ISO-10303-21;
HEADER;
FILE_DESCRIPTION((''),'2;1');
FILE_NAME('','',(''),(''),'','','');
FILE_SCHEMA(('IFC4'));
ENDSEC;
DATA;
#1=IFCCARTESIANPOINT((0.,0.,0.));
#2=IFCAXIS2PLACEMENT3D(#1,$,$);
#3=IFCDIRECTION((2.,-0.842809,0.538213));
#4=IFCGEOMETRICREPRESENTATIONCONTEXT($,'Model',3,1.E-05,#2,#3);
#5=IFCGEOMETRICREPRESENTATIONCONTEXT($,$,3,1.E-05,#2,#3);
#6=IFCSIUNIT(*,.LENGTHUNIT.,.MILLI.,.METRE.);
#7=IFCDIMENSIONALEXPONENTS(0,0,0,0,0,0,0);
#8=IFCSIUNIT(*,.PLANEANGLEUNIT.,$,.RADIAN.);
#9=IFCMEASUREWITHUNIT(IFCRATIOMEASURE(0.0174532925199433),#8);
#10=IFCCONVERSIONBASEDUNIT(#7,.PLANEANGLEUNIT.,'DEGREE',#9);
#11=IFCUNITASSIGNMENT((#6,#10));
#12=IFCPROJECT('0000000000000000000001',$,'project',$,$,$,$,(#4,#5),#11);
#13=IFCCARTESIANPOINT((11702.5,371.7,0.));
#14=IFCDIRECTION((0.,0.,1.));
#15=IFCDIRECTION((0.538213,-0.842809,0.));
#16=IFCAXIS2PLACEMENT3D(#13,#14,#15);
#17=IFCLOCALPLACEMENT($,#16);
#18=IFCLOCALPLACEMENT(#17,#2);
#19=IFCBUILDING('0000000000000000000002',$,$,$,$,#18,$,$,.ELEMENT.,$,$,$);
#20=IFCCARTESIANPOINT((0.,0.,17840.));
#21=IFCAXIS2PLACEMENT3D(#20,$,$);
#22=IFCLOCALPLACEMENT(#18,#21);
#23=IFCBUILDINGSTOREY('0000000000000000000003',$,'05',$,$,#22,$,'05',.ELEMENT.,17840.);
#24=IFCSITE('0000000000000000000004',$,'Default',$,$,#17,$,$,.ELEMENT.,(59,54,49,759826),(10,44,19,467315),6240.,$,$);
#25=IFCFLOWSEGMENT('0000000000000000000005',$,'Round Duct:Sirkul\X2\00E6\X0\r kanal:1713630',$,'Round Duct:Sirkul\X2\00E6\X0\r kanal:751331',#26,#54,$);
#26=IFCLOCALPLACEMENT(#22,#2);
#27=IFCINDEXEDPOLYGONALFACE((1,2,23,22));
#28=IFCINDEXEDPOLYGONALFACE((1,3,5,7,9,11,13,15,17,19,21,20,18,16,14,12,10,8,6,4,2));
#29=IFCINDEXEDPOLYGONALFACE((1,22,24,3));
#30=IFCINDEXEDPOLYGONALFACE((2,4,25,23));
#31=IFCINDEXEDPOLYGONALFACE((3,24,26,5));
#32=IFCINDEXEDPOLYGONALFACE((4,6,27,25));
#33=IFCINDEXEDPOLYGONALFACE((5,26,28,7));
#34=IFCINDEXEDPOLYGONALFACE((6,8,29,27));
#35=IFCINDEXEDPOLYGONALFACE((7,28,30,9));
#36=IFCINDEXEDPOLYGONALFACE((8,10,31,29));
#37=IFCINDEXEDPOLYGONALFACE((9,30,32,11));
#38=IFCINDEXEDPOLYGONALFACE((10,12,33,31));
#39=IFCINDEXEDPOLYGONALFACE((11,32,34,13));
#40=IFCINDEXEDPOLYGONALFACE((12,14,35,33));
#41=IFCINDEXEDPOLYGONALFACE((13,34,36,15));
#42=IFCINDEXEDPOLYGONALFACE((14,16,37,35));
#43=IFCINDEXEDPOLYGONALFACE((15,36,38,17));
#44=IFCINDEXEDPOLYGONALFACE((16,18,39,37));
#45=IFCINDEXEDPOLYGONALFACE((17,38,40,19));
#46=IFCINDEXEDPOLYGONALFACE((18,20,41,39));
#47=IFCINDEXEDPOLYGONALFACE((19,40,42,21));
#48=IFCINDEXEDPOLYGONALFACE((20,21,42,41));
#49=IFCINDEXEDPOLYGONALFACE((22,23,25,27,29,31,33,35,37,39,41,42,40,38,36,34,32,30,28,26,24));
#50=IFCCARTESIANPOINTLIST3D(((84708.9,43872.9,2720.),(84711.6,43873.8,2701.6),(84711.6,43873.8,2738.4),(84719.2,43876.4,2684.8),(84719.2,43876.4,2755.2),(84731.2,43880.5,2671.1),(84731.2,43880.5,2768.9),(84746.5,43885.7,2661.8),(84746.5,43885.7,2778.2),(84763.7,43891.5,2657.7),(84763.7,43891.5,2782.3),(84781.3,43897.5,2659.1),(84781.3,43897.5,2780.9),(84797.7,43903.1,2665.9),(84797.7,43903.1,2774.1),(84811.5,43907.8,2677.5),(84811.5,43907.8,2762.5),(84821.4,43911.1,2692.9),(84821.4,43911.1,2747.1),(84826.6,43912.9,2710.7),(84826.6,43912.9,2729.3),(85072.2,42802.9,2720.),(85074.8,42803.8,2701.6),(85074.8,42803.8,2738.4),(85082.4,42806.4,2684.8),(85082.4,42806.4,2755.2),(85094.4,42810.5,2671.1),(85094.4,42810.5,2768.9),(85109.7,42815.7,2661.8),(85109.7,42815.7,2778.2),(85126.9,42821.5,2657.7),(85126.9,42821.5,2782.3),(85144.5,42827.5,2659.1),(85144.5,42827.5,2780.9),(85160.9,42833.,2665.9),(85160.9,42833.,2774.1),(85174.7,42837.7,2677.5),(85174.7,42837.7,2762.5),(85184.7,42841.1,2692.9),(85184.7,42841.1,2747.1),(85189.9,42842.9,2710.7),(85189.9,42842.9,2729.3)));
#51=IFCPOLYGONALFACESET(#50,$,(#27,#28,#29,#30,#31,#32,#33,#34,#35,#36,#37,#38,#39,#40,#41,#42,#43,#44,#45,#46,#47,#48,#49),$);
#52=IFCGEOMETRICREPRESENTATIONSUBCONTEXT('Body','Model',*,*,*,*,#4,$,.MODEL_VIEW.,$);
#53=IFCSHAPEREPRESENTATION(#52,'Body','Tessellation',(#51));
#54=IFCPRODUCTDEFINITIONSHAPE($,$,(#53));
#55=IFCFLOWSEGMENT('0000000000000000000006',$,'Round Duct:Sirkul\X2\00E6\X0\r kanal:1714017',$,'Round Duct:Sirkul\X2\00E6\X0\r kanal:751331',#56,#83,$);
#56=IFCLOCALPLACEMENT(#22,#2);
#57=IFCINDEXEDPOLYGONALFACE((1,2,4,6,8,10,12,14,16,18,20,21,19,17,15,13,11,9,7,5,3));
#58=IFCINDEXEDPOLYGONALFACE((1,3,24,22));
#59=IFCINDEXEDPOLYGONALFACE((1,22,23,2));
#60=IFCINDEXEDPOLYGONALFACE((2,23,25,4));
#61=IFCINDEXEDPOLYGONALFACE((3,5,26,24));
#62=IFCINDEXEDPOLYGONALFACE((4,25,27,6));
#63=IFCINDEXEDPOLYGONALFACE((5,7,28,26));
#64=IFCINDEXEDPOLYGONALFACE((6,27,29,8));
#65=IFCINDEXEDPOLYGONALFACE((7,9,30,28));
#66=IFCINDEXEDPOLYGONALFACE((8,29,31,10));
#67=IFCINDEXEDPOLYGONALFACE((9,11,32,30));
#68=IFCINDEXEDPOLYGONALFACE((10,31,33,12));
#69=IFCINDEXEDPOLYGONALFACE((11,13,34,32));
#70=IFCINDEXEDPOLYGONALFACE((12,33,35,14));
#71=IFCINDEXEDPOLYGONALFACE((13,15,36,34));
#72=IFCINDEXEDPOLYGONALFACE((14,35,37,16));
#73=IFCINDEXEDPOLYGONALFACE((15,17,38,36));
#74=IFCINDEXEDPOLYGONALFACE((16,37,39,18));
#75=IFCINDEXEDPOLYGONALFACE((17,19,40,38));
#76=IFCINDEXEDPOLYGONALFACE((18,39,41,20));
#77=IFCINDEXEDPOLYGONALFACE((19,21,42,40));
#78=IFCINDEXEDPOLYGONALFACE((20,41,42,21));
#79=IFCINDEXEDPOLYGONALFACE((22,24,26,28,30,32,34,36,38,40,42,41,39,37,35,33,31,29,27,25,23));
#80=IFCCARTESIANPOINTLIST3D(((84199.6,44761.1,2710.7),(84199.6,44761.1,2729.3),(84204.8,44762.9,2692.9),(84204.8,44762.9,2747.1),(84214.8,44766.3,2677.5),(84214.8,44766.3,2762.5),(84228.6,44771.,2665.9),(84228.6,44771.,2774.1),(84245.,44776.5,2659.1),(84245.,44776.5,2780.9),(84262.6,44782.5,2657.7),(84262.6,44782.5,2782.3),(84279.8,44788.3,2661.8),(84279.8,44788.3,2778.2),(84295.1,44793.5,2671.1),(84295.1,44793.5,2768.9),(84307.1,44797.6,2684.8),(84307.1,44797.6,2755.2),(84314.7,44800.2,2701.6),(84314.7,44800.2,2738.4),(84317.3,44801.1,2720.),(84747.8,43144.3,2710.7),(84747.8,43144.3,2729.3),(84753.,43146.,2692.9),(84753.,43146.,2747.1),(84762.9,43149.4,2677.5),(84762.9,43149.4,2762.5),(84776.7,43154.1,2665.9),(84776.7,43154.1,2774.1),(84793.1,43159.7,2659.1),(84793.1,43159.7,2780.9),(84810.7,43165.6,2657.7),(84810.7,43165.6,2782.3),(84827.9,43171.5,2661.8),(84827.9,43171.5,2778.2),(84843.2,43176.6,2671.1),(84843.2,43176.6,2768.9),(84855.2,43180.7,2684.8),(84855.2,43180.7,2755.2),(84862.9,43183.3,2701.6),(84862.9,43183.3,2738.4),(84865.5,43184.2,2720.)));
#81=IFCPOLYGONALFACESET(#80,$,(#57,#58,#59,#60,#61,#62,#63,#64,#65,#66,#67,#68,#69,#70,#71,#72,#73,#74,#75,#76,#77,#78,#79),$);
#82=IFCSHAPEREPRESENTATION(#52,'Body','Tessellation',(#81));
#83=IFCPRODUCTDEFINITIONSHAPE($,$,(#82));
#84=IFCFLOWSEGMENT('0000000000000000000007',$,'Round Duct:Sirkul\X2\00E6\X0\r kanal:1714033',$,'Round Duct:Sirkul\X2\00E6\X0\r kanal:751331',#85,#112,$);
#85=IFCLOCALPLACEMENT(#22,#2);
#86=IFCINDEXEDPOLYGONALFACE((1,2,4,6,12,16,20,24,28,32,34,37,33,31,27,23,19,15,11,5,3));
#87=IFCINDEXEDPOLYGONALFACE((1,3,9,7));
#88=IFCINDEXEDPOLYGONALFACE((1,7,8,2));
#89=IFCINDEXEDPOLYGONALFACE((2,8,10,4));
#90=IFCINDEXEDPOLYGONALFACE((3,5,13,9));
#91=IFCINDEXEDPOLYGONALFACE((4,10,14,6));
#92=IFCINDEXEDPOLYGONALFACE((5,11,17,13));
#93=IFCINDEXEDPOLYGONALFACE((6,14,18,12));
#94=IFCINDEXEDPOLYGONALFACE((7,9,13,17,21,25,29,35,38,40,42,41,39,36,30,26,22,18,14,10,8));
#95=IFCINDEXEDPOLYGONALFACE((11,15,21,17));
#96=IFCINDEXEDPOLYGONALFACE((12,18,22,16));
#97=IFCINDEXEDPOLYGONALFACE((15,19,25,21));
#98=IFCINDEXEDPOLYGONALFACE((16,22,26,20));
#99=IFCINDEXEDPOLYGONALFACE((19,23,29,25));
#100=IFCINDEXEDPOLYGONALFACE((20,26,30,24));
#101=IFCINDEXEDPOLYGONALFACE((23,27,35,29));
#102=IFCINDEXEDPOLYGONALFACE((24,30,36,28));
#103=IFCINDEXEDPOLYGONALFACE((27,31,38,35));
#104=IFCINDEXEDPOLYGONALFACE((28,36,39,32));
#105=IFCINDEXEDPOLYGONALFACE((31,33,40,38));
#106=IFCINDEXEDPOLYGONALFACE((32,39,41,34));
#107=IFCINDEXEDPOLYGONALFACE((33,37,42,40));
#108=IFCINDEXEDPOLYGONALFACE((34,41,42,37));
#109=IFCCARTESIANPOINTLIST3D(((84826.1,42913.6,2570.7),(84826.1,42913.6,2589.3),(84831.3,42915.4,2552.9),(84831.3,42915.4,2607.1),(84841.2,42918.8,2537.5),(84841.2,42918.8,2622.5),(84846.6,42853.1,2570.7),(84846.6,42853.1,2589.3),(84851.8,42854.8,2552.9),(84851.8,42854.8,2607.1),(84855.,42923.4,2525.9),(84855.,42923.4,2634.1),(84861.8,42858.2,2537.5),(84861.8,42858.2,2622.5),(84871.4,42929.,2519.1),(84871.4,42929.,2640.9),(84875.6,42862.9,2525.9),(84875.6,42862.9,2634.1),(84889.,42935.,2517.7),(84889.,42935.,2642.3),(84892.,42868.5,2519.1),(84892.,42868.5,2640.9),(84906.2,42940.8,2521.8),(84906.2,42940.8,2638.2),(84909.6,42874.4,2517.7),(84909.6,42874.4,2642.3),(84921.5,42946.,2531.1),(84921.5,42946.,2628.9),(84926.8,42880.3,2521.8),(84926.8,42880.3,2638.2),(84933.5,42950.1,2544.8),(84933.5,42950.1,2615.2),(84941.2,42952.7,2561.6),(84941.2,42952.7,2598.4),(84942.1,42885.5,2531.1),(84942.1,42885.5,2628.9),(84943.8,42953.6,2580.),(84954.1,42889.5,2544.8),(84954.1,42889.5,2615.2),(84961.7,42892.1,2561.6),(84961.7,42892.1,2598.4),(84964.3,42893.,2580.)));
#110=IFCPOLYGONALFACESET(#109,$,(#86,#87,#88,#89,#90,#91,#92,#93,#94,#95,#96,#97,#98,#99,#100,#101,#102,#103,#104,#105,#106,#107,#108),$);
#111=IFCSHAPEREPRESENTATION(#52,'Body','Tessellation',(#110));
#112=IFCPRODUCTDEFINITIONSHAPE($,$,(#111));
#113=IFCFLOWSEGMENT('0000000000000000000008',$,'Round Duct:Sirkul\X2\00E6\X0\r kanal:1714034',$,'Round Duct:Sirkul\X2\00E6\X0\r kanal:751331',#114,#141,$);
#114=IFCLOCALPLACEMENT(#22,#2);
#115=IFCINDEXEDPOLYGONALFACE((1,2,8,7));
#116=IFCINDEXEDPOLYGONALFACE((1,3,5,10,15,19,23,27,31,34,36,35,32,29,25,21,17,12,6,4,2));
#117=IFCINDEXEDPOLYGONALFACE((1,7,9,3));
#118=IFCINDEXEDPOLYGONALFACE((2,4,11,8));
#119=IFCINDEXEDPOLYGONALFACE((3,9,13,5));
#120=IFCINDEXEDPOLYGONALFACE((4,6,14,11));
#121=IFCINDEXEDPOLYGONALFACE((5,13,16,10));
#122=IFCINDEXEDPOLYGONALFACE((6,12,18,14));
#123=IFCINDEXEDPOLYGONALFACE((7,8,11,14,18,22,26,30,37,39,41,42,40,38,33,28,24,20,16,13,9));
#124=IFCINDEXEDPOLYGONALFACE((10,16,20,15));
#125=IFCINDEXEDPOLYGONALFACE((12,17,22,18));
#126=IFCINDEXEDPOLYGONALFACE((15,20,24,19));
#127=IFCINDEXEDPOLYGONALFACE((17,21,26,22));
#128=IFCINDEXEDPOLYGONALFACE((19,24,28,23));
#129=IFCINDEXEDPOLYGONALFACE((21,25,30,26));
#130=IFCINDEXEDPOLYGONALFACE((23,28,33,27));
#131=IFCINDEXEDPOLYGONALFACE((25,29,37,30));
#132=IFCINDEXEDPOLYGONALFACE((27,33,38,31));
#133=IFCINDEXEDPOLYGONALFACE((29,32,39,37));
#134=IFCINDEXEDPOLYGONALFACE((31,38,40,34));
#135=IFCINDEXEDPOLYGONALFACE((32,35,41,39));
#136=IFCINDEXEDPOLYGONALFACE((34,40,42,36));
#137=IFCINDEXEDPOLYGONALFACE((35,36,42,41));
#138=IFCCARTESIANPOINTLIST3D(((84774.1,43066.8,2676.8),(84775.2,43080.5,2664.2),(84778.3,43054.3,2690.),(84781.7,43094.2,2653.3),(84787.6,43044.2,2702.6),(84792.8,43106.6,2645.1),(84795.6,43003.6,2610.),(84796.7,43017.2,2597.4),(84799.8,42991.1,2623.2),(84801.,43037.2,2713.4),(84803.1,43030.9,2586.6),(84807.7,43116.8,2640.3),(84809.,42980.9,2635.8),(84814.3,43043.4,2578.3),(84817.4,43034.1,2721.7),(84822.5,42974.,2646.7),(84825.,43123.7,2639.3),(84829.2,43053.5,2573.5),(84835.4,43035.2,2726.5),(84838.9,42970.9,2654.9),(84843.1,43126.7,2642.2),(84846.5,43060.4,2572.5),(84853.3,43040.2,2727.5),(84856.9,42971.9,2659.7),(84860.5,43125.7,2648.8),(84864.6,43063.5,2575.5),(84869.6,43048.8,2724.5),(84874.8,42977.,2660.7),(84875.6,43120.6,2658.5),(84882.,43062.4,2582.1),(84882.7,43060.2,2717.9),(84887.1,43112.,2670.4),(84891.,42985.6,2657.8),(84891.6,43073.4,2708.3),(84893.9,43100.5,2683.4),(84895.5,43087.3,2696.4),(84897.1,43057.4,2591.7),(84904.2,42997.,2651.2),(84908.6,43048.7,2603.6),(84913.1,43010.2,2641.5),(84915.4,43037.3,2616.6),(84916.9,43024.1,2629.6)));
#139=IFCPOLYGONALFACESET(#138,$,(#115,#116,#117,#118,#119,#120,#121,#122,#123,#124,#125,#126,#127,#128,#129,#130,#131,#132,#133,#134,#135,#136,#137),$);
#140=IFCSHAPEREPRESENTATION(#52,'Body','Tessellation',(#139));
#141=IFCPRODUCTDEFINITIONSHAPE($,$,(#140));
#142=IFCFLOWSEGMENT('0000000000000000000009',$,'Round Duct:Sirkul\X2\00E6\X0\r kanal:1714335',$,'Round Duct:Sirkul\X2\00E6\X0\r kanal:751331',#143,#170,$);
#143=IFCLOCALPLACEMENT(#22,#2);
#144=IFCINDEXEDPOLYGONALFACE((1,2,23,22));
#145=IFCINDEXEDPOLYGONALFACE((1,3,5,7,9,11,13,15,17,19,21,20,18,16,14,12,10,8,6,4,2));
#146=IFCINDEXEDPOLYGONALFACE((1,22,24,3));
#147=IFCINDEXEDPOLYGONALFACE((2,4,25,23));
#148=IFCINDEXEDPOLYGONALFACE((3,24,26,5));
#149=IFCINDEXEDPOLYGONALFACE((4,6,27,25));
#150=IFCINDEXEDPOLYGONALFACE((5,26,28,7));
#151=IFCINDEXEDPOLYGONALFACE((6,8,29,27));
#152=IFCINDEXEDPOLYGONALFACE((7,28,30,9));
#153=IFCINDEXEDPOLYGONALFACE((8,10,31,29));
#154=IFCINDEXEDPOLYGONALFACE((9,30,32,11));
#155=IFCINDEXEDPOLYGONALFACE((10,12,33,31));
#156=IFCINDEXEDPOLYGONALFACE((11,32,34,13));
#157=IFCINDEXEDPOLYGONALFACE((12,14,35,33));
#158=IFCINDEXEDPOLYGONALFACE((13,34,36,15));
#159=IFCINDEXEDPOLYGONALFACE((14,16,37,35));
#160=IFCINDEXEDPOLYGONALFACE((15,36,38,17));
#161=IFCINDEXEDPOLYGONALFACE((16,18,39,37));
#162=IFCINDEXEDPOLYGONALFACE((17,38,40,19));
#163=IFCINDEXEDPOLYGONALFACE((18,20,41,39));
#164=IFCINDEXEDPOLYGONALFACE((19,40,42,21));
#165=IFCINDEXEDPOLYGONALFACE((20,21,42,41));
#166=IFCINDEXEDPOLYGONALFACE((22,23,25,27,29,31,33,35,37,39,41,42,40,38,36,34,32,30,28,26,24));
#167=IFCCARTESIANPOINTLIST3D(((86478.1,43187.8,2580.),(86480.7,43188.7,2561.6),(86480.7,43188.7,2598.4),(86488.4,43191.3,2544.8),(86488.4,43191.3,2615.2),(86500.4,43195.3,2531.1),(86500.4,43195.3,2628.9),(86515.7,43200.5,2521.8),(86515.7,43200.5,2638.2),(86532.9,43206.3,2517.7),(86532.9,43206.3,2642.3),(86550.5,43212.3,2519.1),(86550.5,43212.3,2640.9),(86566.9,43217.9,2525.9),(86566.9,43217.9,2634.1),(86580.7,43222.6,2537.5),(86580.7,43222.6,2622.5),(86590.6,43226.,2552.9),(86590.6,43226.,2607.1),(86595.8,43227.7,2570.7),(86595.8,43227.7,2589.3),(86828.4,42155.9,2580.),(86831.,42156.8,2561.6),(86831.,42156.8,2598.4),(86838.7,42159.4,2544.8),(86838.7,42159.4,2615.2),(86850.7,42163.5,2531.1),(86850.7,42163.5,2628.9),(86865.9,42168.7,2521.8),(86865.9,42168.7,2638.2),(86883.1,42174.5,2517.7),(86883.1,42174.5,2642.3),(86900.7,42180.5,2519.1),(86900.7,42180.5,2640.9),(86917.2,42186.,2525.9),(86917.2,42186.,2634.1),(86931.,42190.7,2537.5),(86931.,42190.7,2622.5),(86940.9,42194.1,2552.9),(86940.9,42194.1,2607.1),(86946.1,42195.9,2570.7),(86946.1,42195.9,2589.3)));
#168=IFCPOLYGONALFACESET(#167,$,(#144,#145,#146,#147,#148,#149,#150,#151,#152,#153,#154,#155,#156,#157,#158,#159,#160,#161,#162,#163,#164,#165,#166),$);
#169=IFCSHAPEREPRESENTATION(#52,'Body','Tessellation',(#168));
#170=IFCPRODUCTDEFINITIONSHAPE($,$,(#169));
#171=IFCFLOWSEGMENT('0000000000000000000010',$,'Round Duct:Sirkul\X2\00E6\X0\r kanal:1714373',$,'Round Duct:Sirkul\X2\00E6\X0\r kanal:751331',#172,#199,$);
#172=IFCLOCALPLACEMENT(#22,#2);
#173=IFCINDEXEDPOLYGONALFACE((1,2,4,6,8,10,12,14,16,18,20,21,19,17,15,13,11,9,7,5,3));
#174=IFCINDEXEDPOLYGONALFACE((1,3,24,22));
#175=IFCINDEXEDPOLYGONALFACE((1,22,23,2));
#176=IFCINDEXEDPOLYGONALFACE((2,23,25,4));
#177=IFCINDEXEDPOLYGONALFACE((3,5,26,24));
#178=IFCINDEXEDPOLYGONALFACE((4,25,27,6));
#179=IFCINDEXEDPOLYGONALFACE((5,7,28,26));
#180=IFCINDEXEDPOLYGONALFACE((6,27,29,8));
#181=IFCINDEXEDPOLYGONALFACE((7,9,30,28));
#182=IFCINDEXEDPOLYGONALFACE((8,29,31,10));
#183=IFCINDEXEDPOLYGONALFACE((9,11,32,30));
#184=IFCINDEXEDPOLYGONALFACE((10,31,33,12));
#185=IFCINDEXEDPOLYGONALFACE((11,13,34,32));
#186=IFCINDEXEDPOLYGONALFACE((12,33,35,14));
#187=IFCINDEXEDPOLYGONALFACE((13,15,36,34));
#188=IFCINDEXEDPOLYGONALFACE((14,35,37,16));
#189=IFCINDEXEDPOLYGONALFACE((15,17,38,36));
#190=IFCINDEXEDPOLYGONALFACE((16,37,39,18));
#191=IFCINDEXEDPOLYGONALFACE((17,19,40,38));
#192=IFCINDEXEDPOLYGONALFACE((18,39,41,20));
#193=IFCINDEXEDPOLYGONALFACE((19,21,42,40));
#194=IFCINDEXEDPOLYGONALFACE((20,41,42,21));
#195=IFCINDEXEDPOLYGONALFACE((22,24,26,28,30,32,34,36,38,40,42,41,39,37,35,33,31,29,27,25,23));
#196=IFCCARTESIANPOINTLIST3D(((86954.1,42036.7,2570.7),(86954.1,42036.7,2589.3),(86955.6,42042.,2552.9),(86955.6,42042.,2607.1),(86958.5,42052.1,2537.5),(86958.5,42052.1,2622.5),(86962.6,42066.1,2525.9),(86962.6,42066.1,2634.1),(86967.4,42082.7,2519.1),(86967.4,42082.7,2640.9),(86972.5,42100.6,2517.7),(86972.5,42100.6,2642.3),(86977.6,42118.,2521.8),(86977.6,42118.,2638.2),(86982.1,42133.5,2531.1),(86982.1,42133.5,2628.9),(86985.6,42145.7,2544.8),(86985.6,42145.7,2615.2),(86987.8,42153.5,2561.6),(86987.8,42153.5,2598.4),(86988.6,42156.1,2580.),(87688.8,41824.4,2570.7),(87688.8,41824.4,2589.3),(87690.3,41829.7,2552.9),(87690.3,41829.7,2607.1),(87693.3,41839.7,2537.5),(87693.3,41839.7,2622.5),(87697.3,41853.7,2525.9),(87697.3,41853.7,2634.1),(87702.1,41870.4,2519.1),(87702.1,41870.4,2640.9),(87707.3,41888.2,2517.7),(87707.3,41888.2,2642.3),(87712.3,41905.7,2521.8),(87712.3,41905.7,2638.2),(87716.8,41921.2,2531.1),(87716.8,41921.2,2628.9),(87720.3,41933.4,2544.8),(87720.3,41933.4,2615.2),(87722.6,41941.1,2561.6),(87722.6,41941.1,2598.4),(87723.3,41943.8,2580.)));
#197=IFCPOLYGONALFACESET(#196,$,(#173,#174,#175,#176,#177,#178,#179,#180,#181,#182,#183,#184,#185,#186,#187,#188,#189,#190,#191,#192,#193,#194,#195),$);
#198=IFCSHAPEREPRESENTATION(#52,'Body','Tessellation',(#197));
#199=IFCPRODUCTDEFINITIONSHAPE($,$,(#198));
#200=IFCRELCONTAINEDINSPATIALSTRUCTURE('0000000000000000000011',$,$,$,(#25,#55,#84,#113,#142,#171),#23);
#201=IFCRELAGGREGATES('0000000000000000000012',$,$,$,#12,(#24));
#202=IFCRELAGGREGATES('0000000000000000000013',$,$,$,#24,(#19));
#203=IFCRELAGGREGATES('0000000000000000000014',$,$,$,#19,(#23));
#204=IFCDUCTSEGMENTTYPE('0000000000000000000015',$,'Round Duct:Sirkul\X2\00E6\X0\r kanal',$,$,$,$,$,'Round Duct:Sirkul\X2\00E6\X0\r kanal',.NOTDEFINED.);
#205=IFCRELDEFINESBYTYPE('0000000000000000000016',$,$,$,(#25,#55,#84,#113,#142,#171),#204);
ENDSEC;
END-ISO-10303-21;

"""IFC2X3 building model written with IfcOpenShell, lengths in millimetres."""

from ifc_helpers import new_model, entity, si_unit, converted_unit, direction, frame, origin, origin_2d_with_axis, place, context, subcontext, project, spatial, circle, extrude, type_object, element, save


model = new_model("IFC2X3")

# Units and contexts
model_context = context("Model", 3, precision=1e-05, world=origin(), true_north=direction((2.0, -0.842809, 0.538213)))
context_of_model = context(None, 3, precision=1e-05, world=origin(), true_north=direction((2.0, -0.842809, 0.538213)))
body_context = subcontext(model_context, "Body", "Model", "MODEL_VIEW")
ifc_project = project(units=[si_unit("LENGTHUNIT", "METRE", prefix="MILLI"), converted_unit("PLANEANGLEUNIT", "DEGREE", entity("IfcRatioMeasure", 0.0174532925199433), si_unit("PLANEANGLEUNIT", "RADIAN"), dimensions=[0, 0, 0, 0, 0, 0, 0])], contexts=[model_context, context_of_model])

# Site, building, storey
site_placement = place(None, frame((11702.5, 371.7, 0.0), z_axis=(0.0, 0.0, 1.0), x_axis=(0.538213, -0.842809, 0.0)))
site = spatial("IfcSite", under=ifc_project, at=site_placement, Name="Default", CompositionType="ELEMENT", RefLatitude=(59, 54, 49, 759826), RefLongitude=(10, 44, 19, 467315), RefElevation=6240.0)
building_placement = place(site_placement, origin())
building = spatial("IfcBuilding", under=site, at=building_placement, CompositionType="ELEMENT")
storey_placement = place(building_placement, frame((0.0, 0.0, 17840.0)))
storey = spatial("IfcBuildingStorey", under=building, at=storey_placement, Name="05", LongName="05", CompositionType="ELEMENT", Elevation=17840.0)

# Flow segments
duct_segment_type = type_object("IfcDuctSegmentType", Name="Round Duct:Sirkulær kanal", ElementType="Round Duct:Sirkulær kanal", PredefinedType="NOTDEFINED")
flow_segment_1_placement = place(storey_placement, origin())
element("IfcFlowSegment", 1, at=flow_segment_1_placement, inside=storey, type_object=duct_segment_type, Name="Round Duct:Sirkulær kanal:1713630", ObjectType="Round Duct:Sirkulær kanal:751331", context=body_context, shape_type="SweptSolid", body=[
    extrude(circle(Radius=62.5, at=origin_2d_with_axis()), frame((84768.1, 43893.0, 2720.0), z_axis=(0.321439, -0.94693, 0.0), x_axis=(-0.94693, -0.321439, 0.0)), (0.0, 0.0, 1.0), 1130.0),
])
flow_segment_2_placement = place(storey_placement, origin())
element("IfcFlowSegment", 2, at=flow_segment_2_placement, inside=storey, type_object=duct_segment_type, Name="Round Duct:Sirkulær kanal:1714017", ObjectType="Round Duct:Sirkulær kanal:751331", context=body_context, shape_type="SweptSolid", body=[
    extrude(circle(Radius=62.5, at=origin_2d_with_axis()), frame((84258.2, 44781.0, 2720.0), z_axis=(0.321081, -0.947052, 0.0), x_axis=(0.947052, 0.321081, 0.0)), (0.0, 0.0, 1.0), 1707.3),
])
flow_segment_3_placement = place(storey_placement, origin())
element("IfcFlowSegment", 3, at=flow_segment_3_placement, inside=storey, type_object=duct_segment_type, Name="Round Duct:Sirkulær kanal:1714033", ObjectType="Round Duct:Sirkulær kanal:751331", context=body_context, shape_type="SweptSolid", body=[
    extrude(circle(Radius=62.5, at=origin_2d_with_axis()), frame((84884.6, 42933.5, 2580.0), z_axis=(0.321439, -0.94693, 0.0), x_axis=(0.94693, 0.321439, 0.0)), (0.0, 0.0, 1.0), 63.9),
])
flow_segment_4_placement = place(storey_placement, origin())
element("IfcFlowSegment", 4, at=flow_segment_4_placement, inside=storey, type_object=duct_segment_type, Name="Round Duct:Sirkulær kanal:1714034", ObjectType="Round Duct:Sirkulær kanal:751331", context=body_context, shape_type="SweptSolid", body=[
    extrude(circle(Radius=62.5, at=origin_2d_with_axis()), frame((84856.2, 43017.2, 2616.6), z_axis=(-0.227292, 0.669581, 0.707107), x_axis=(0.94693, 0.321439, 0.0)), (0.0, 0.0, 1.0), 94.4),
])
flow_segment_5_placement = place(storey_placement, origin())
element("IfcFlowSegment", 5, at=flow_segment_5_placement, inside=storey, type_object=duct_segment_type, Name="Round Duct:Sirkulær kanal:1714335", ObjectType="Round Duct:Sirkulær kanal:751331", context=body_context, shape_type="SweptSolid", body=[
    extrude(circle(Radius=62.5, at=origin_2d_with_axis()), frame((86537.3, 43207.9, 2580.0), z_axis=(0.321439, -0.94693, 0.0), x_axis=(-0.94693, -0.321439, 0.0)), (0.0, 0.0, 1.0), 1089.7),
])
flow_segment_6_placement = place(storey_placement, origin())
element("IfcFlowSegment", 6, at=flow_segment_6_placement, inside=storey, type_object=duct_segment_type, Name="Round Duct:Sirkulær kanal:1714373", ObjectType="Round Duct:Sirkulær kanal:751331", context=body_context, shape_type="SweptSolid", body=[
    extrude(circle(Radius=62.5, at=origin_2d_with_axis()), frame((86971.2, 42096.1, 2580.0), z_axis=(0.960686, -0.277638, 0.0), x_axis=(0.277638, 0.960686, 0.0)), (0.0, 0.0, 1.0), 764.8),
])

save(model, "model.ifc")
